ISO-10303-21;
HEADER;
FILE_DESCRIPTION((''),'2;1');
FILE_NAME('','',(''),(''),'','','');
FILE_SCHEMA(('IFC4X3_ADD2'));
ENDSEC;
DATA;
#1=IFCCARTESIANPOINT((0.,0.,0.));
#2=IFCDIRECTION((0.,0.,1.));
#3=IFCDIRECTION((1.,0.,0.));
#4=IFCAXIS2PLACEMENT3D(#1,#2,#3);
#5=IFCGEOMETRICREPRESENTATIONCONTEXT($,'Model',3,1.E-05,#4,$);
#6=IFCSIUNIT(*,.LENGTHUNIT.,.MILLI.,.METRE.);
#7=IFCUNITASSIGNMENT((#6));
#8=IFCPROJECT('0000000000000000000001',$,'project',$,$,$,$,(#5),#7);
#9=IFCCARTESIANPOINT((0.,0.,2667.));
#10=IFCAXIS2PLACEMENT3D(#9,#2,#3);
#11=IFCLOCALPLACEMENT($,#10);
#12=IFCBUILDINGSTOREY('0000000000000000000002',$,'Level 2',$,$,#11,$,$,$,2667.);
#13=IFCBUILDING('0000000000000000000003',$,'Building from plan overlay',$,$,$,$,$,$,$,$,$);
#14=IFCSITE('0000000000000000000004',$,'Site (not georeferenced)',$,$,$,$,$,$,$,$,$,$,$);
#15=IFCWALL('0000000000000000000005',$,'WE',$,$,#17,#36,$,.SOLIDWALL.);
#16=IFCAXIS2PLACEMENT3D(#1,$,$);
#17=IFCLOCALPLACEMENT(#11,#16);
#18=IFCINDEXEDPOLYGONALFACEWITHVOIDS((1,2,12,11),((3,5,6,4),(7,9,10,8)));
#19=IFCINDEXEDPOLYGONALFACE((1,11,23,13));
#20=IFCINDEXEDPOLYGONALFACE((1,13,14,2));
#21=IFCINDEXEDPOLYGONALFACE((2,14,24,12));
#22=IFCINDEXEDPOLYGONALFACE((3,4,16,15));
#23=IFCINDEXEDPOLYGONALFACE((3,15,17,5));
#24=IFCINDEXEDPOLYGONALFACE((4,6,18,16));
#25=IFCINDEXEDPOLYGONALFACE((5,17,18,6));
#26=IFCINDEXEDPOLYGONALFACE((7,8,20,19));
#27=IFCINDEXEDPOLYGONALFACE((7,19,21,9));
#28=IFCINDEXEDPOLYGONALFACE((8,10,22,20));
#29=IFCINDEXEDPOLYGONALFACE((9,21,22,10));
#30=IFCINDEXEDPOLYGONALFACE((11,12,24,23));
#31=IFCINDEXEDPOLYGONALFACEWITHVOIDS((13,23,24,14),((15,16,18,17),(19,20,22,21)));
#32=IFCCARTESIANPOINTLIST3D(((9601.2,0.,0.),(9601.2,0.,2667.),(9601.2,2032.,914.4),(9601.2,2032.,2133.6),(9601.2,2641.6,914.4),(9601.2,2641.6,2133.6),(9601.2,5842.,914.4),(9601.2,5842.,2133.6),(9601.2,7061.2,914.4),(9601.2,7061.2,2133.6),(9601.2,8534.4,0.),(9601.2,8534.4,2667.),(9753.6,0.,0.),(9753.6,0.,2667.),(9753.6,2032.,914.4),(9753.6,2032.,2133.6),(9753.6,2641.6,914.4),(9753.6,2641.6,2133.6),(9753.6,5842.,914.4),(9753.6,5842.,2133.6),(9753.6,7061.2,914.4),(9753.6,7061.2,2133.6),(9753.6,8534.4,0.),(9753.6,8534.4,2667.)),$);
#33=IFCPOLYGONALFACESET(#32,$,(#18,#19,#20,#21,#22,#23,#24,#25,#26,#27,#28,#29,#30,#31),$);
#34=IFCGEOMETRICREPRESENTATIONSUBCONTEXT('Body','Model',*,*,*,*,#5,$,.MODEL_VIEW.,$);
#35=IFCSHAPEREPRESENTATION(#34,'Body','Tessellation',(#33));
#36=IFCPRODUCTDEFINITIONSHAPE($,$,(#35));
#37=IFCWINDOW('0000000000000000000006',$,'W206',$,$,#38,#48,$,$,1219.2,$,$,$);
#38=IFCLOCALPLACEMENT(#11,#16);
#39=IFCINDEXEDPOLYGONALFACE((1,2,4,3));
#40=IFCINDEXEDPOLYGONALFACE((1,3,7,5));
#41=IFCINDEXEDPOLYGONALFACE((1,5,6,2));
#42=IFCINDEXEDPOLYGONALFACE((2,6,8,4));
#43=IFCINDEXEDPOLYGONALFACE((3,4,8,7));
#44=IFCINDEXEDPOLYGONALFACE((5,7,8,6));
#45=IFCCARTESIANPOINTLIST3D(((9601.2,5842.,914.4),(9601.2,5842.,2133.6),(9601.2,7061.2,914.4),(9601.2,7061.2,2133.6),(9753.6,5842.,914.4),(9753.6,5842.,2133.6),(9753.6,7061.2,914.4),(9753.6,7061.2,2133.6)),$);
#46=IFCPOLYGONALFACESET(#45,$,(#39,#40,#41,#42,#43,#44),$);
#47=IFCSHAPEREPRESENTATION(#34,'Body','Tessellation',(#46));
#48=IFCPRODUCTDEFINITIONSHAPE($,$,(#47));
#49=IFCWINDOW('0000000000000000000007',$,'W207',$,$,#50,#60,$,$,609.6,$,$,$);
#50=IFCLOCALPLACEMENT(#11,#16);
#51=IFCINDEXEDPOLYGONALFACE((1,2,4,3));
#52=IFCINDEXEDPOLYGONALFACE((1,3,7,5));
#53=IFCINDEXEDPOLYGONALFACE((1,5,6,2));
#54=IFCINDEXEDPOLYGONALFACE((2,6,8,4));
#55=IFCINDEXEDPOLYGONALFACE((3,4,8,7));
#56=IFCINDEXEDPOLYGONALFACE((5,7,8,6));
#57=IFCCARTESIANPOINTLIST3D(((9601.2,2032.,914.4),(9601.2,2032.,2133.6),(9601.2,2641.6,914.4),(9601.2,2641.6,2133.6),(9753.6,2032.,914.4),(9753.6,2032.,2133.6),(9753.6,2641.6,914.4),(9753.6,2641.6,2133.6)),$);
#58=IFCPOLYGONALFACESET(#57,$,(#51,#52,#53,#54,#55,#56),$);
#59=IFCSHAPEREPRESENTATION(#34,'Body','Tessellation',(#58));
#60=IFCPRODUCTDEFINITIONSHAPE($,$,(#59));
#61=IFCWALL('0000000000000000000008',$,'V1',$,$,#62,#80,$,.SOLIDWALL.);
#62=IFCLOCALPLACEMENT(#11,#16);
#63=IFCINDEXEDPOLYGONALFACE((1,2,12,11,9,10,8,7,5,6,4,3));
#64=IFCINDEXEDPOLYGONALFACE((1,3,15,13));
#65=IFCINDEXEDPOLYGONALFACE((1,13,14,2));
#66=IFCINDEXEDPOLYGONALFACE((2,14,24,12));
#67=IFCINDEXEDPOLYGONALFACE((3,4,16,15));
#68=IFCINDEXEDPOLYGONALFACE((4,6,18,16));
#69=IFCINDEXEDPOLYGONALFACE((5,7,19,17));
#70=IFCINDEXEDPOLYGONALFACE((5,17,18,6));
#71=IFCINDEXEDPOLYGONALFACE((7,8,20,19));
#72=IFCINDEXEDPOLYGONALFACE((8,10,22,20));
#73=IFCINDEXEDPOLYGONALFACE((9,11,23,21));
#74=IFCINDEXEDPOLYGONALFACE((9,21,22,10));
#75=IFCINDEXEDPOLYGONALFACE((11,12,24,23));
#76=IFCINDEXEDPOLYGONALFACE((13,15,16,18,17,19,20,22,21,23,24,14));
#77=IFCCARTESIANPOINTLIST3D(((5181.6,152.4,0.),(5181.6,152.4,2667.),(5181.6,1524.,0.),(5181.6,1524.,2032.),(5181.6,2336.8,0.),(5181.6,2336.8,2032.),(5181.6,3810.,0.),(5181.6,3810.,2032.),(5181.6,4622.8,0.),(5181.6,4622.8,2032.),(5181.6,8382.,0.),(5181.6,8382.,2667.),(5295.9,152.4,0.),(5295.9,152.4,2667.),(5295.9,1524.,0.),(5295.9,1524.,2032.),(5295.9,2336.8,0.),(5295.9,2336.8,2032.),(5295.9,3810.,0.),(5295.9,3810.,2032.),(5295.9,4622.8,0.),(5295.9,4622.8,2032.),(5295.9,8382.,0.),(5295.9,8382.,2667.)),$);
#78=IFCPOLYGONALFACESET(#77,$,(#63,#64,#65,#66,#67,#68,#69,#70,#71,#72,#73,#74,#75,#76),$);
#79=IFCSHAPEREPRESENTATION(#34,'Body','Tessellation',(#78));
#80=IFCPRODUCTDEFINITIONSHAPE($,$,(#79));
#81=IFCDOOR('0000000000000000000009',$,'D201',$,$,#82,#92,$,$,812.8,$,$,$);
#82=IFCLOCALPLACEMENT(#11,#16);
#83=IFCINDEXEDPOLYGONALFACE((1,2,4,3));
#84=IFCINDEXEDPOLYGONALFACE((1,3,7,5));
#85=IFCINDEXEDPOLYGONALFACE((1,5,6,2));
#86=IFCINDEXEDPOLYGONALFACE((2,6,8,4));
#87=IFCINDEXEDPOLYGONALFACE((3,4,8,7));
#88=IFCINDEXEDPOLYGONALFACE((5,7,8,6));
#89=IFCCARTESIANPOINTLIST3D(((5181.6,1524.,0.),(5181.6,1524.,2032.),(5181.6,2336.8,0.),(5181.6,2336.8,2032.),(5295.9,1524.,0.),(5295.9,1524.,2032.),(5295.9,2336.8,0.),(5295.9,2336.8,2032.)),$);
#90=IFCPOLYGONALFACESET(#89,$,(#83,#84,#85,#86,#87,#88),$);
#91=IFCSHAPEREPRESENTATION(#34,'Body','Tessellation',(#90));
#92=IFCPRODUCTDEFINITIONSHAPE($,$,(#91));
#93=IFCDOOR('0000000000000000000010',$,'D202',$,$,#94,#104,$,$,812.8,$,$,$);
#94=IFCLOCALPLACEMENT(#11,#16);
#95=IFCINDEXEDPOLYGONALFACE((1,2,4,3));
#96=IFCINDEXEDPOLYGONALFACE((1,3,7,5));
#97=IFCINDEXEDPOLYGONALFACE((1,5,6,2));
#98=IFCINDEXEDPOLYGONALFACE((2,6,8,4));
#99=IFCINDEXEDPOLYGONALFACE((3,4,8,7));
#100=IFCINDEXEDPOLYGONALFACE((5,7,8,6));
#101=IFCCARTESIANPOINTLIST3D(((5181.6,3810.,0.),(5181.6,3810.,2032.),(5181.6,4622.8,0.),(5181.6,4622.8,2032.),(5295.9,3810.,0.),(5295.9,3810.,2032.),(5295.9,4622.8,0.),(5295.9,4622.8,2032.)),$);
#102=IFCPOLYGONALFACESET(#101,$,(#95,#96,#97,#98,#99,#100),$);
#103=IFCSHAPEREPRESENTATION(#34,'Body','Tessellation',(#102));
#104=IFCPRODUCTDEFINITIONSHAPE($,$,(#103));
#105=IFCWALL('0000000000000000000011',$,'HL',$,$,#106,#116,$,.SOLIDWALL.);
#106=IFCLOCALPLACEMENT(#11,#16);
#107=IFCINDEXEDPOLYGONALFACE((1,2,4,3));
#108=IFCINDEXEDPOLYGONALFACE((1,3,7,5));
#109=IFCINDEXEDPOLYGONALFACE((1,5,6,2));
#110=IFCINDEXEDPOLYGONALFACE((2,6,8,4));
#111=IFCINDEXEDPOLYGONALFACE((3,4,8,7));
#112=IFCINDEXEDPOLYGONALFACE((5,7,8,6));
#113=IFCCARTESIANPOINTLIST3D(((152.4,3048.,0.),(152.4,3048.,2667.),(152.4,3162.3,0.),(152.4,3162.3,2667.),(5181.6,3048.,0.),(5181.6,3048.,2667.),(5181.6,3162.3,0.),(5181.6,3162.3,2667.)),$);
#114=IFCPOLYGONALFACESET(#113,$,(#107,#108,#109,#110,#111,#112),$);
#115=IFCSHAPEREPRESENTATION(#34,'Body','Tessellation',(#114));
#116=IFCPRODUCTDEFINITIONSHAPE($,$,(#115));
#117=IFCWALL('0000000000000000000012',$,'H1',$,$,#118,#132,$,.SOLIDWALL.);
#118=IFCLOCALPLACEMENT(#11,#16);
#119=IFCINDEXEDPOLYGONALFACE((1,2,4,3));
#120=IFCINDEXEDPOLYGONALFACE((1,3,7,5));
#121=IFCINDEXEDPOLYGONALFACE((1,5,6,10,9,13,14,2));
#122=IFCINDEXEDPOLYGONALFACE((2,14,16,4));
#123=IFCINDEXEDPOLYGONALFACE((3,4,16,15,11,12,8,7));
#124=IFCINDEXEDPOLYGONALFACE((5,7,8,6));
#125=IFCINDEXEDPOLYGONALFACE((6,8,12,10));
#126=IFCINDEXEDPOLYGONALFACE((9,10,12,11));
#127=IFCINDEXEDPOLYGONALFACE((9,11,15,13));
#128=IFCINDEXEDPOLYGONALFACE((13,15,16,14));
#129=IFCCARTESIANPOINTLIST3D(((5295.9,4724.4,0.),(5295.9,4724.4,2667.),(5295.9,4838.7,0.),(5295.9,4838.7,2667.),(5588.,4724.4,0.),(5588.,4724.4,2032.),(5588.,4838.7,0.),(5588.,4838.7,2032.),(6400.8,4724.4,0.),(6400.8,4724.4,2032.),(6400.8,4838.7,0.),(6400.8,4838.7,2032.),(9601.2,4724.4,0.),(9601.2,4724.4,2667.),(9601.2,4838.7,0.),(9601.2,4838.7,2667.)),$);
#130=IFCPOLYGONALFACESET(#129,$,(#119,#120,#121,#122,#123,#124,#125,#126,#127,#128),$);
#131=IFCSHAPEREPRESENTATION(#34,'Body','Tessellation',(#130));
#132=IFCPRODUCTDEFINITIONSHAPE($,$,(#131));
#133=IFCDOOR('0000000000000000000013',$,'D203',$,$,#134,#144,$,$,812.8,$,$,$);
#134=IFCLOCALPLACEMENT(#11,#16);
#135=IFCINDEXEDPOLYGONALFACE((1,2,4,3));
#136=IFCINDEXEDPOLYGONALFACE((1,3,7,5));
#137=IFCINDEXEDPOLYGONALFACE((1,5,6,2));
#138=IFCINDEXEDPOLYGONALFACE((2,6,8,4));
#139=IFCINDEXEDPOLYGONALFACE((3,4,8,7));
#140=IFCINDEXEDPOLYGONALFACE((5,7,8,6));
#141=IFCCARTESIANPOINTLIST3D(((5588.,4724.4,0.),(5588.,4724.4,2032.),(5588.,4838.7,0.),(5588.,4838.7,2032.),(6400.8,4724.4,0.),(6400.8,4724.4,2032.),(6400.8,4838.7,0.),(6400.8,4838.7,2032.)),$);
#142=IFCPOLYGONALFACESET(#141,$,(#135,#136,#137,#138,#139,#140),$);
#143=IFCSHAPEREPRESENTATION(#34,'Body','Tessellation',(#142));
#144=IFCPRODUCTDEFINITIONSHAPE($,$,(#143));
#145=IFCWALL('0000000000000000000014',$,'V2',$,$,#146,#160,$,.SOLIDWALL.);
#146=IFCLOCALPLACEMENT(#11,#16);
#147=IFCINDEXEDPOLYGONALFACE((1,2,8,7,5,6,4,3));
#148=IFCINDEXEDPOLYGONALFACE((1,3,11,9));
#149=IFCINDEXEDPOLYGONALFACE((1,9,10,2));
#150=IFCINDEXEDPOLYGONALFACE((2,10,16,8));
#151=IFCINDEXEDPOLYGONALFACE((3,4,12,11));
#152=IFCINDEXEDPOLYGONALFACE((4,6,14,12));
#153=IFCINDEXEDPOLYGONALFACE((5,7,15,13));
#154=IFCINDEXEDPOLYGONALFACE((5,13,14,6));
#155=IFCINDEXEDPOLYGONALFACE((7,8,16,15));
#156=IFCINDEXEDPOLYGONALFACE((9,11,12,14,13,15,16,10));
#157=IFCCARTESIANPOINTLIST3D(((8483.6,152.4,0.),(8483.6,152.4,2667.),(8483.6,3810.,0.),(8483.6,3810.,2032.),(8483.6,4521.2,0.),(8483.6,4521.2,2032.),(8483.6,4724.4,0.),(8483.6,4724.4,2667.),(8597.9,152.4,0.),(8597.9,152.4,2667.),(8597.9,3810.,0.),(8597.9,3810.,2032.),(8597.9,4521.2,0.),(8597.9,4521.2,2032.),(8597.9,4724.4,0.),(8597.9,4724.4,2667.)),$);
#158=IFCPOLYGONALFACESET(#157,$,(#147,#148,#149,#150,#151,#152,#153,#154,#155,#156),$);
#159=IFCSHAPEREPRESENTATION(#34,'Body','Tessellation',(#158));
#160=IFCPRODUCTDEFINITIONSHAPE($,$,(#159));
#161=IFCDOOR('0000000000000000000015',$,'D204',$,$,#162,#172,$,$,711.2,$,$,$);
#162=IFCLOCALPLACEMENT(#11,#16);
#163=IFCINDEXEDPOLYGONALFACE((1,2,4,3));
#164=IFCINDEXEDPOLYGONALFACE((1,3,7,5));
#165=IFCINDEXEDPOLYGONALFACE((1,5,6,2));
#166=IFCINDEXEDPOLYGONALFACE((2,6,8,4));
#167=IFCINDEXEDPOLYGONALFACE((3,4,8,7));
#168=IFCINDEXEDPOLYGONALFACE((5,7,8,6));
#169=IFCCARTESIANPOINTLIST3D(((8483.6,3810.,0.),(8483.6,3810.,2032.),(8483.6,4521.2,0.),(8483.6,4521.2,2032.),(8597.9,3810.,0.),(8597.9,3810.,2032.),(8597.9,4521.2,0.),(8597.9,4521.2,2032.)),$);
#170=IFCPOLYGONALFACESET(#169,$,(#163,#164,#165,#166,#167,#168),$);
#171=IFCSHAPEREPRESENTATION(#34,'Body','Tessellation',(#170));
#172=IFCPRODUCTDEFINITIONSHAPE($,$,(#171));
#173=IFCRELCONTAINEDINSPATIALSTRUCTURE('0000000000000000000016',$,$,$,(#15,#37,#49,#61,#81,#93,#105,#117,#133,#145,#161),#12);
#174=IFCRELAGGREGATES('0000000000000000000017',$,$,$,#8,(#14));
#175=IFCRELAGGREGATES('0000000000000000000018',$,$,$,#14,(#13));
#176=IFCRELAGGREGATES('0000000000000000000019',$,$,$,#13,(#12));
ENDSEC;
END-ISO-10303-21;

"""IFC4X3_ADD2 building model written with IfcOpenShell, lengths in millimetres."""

from ifc_helpers import new_model, si_unit, frame, origin, origin_with_axes, place, context, subcontext, project, spatial, polyline, outline, extrude, element, fill, save


model = new_model("IFC4X3_ADD2")

# Units and contexts
model_context = context("Model", 3, precision=1e-05, world=origin_with_axes())
body_context = subcontext(model_context, "Body", "Model", "MODEL_VIEW")
ifc_project = project(units=[si_unit("LENGTHUNIT", "METRE", prefix="MILLI")], contexts=[model_context])

# Site, building, storey
site = spatial("IfcSite", under=ifc_project, Name="Site (not georeferenced)")
building = spatial("IfcBuilding", under=site, Name="Building from plan overlay")
storey_placement = place(None, frame((0.0, 0.0, 2667.0), z_axis=(0.0, 0.0, 1.0), x_axis=(1.0, 0.0, 0.0)))
storey = spatial("IfcBuildingStorey", under=building, at=storey_placement, Name="Level 2", Elevation=2667.0)

# Wall, openings, windows
wall_1_placement = place(storey_placement, origin_with_axes())
wall_1 = element("IfcWall", 1, at=wall_1_placement, inside=storey, Name="WE", PredefinedType="SOLIDWALL", context=body_context, shape_type="SweptSolid", body=[
    extrude(outline(polyline([(9601.2, 0.0), (9753.6, 0.0), (9753.6, 8534.4), (9601.2, 8534.4), (9601.2, 0.0)])), origin(), (0.0, 0.0, 1.0), 2667.0),
])
opening_1_placement = place(wall_1_placement, origin_with_axes())
opening_1 = element("IfcOpeningElement", 2, at=opening_1_placement, cuts=wall_1, context=body_context, shape_type="SweptSolid", body=[
    extrude(outline(polyline([(9601.2, 5842.0), (9753.6, 5842.0), (9753.6, 7061.2), (9601.2, 7061.2), (9601.2, 5842.0)])), frame((0.0, 0.0, 914.4)), (0.0, 0.0, 1.0), 1219.2),
])
opening_2_placement = place(wall_1_placement, origin_with_axes())
opening_2 = element("IfcOpeningElement", 3, at=opening_2_placement, cuts=wall_1, context=body_context, shape_type="SweptSolid", body=[
    extrude(outline(polyline([(9601.2, 2032.0), (9753.6, 2032.0), (9753.6, 2641.6), (9601.2, 2641.6), (9601.2, 2032.0)])), frame((0.0, 0.0, 914.4)), (0.0, 0.0, 1.0), 1219.2),
])
window_1_placement = place(storey_placement, origin_with_axes())
window_1 = element("IfcWindow", 4, at=window_1_placement, inside=storey, Name="W206", OverallWidth=1219.2, context=body_context, shape_type="SweptSolid", body=[
    extrude(outline(polyline([(9601.2, 5842.0), (9753.6, 5842.0), (9753.6, 7061.2), (9601.2, 7061.2), (9601.2, 5842.0)])), frame((0.0, 0.0, 914.4)), (0.0, 0.0, 1.0), 1219.2),
])
fill(opening_1, window_1)
window_2_placement = place(storey_placement, origin_with_axes())
window_2 = element("IfcWindow", 5, at=window_2_placement, inside=storey, Name="W207", OverallWidth=609.6, context=body_context, shape_type="SweptSolid", body=[
    extrude(outline(polyline([(9601.2, 2032.0), (9753.6, 2032.0), (9753.6, 2641.6), (9601.2, 2641.6), (9601.2, 2032.0)])), frame((0.0, 0.0, 914.4)), (0.0, 0.0, 1.0), 1219.2),
])
fill(opening_2, window_2)

# Wall, openings, doors
wall_2_placement = place(storey_placement, origin_with_axes())
wall_2 = element("IfcWall", 6, at=wall_2_placement, inside=storey, Name="V1", PredefinedType="SOLIDWALL", context=body_context, shape_type="SweptSolid", body=[
    extrude(outline(polyline([(5181.6, 152.4), (5295.9, 152.4), (5295.9, 8382.0), (5181.6, 8382.0), (5181.6, 152.4)])), origin(), (0.0, 0.0, 1.0), 2667.0),
])
opening_3_placement = place(wall_2_placement, origin_with_axes())
opening_3 = element("IfcOpeningElement", 7, at=opening_3_placement, cuts=wall_2, context=body_context, shape_type="SweptSolid", body=[
    extrude(outline(polyline([(5181.6, 1524.0), (5295.9, 1524.0), (5295.9, 2336.8), (5181.6, 2336.8), (5181.6, 1524.0)])), origin(), (0.0, 0.0, 1.0), 2032.0),
])
opening_4_placement = place(wall_2_placement, origin_with_axes())
opening_4 = element("IfcOpeningElement", 8, at=opening_4_placement, cuts=wall_2, context=body_context, shape_type="SweptSolid", body=[
    extrude(outline(polyline([(5181.6, 3810.0), (5295.9, 3810.0), (5295.9, 4622.8), (5181.6, 4622.8), (5181.6, 3810.0)])), origin(), (0.0, 0.0, 1.0), 2032.0),
])
door_1_placement = place(storey_placement, origin_with_axes())
door_1 = element("IfcDoor", 9, at=door_1_placement, inside=storey, Name="D201", OverallWidth=812.8, context=body_context, shape_type="SweptSolid", body=[
    extrude(outline(polyline([(5181.6, 1524.0), (5295.9, 1524.0), (5295.9, 2336.8), (5181.6, 2336.8), (5181.6, 1524.0)])), origin(), (0.0, 0.0, 1.0), 2032.0),
])
fill(opening_3, door_1)
door_2_placement = place(storey_placement, origin_with_axes())
door_2 = element("IfcDoor", 10, at=door_2_placement, inside=storey, Name="D202", OverallWidth=812.8, context=body_context, shape_type="SweptSolid", body=[
    extrude(outline(polyline([(5181.6, 3810.0), (5295.9, 3810.0), (5295.9, 4622.8), (5181.6, 4622.8), (5181.6, 3810.0)])), origin(), (0.0, 0.0, 1.0), 2032.0),
])
fill(opening_4, door_2)

# Wall
wall_3_placement = place(storey_placement, origin_with_axes())
element("IfcWall", 11, at=wall_3_placement, inside=storey, Name="HL", PredefinedType="SOLIDWALL", context=body_context, shape_type="SweptSolid", body=[
    extrude(outline(polyline([(152.4, 3048.0), (5181.6, 3048.0), (5181.6, 3162.3), (152.4, 3162.3), (152.4, 3048.0)])), origin(), (0.0, 0.0, 1.0), 2667.0),
])

# Walls, openings, doors
wall_4_placement = place(storey_placement, origin_with_axes())
wall_4 = element("IfcWall", 12, at=wall_4_placement, inside=storey, Name="H1", PredefinedType="SOLIDWALL", context=body_context, shape_type="SweptSolid", body=[
    extrude(outline(polyline([(5295.9, 4724.4), (9601.2, 4724.4), (9601.2, 4838.7), (5295.9, 4838.7), (5295.9, 4724.4)])), origin(), (0.0, 0.0, 1.0), 2667.0),
])
opening_5_placement = place(wall_4_placement, origin_with_axes())
opening_5 = element("IfcOpeningElement", 13, at=opening_5_placement, cuts=wall_4, context=body_context, shape_type="SweptSolid", body=[
    extrude(outline(polyline([(5588.0, 4724.4), (6400.8, 4724.4), (6400.8, 4838.7), (5588.0, 4838.7), (5588.0, 4724.4)])), origin(), (0.0, 0.0, 1.0), 2032.0),
])
door_3_placement = place(storey_placement, origin_with_axes())
door_3 = element("IfcDoor", 14, at=door_3_placement, inside=storey, Name="D203", OverallWidth=812.8, context=body_context, shape_type="SweptSolid", body=[
    extrude(outline(polyline([(5588.0, 4724.4), (6400.8, 4724.4), (6400.8, 4838.7), (5588.0, 4838.7), (5588.0, 4724.4)])), origin(), (0.0, 0.0, 1.0), 2032.0),
])
fill(opening_5, door_3)
wall_5_placement = place(storey_placement, origin_with_axes())
wall_5 = element("IfcWall", 15, at=wall_5_placement, inside=storey, Name="V2", PredefinedType="SOLIDWALL", context=body_context, shape_type="SweptSolid", body=[
    extrude(outline(polyline([(8483.6, 152.4), (8597.9, 152.4), (8597.9, 4724.4), (8483.6, 4724.4), (8483.6, 152.4)])), origin(), (0.0, 0.0, 1.0), 2667.0),
])
opening_6_placement = place(wall_5_placement, origin_with_axes())
opening_6 = element("IfcOpeningElement", 16, at=opening_6_placement, cuts=wall_5, context=body_context, shape_type="SweptSolid", body=[
    extrude(outline(polyline([(8483.6, 3810.0), (8597.9, 3810.0), (8597.9, 4521.2), (8483.6, 4521.2), (8483.6, 3810.0)])), origin(), (0.0, 0.0, 1.0), 2032.0),
])
door_4_placement = place(storey_placement, origin_with_axes())
door_4 = element("IfcDoor", 17, at=door_4_placement, inside=storey, Name="D204", OverallWidth=711.2, context=body_context, shape_type="SweptSolid", body=[
    extrude(outline(polyline([(8483.6, 3810.0), (8597.9, 3810.0), (8597.9, 4521.2), (8483.6, 4521.2), (8483.6, 3810.0)])), origin(), (0.0, 0.0, 1.0), 2032.0),
])
fill(opening_6, door_4)

save(model, "model.ifc")
